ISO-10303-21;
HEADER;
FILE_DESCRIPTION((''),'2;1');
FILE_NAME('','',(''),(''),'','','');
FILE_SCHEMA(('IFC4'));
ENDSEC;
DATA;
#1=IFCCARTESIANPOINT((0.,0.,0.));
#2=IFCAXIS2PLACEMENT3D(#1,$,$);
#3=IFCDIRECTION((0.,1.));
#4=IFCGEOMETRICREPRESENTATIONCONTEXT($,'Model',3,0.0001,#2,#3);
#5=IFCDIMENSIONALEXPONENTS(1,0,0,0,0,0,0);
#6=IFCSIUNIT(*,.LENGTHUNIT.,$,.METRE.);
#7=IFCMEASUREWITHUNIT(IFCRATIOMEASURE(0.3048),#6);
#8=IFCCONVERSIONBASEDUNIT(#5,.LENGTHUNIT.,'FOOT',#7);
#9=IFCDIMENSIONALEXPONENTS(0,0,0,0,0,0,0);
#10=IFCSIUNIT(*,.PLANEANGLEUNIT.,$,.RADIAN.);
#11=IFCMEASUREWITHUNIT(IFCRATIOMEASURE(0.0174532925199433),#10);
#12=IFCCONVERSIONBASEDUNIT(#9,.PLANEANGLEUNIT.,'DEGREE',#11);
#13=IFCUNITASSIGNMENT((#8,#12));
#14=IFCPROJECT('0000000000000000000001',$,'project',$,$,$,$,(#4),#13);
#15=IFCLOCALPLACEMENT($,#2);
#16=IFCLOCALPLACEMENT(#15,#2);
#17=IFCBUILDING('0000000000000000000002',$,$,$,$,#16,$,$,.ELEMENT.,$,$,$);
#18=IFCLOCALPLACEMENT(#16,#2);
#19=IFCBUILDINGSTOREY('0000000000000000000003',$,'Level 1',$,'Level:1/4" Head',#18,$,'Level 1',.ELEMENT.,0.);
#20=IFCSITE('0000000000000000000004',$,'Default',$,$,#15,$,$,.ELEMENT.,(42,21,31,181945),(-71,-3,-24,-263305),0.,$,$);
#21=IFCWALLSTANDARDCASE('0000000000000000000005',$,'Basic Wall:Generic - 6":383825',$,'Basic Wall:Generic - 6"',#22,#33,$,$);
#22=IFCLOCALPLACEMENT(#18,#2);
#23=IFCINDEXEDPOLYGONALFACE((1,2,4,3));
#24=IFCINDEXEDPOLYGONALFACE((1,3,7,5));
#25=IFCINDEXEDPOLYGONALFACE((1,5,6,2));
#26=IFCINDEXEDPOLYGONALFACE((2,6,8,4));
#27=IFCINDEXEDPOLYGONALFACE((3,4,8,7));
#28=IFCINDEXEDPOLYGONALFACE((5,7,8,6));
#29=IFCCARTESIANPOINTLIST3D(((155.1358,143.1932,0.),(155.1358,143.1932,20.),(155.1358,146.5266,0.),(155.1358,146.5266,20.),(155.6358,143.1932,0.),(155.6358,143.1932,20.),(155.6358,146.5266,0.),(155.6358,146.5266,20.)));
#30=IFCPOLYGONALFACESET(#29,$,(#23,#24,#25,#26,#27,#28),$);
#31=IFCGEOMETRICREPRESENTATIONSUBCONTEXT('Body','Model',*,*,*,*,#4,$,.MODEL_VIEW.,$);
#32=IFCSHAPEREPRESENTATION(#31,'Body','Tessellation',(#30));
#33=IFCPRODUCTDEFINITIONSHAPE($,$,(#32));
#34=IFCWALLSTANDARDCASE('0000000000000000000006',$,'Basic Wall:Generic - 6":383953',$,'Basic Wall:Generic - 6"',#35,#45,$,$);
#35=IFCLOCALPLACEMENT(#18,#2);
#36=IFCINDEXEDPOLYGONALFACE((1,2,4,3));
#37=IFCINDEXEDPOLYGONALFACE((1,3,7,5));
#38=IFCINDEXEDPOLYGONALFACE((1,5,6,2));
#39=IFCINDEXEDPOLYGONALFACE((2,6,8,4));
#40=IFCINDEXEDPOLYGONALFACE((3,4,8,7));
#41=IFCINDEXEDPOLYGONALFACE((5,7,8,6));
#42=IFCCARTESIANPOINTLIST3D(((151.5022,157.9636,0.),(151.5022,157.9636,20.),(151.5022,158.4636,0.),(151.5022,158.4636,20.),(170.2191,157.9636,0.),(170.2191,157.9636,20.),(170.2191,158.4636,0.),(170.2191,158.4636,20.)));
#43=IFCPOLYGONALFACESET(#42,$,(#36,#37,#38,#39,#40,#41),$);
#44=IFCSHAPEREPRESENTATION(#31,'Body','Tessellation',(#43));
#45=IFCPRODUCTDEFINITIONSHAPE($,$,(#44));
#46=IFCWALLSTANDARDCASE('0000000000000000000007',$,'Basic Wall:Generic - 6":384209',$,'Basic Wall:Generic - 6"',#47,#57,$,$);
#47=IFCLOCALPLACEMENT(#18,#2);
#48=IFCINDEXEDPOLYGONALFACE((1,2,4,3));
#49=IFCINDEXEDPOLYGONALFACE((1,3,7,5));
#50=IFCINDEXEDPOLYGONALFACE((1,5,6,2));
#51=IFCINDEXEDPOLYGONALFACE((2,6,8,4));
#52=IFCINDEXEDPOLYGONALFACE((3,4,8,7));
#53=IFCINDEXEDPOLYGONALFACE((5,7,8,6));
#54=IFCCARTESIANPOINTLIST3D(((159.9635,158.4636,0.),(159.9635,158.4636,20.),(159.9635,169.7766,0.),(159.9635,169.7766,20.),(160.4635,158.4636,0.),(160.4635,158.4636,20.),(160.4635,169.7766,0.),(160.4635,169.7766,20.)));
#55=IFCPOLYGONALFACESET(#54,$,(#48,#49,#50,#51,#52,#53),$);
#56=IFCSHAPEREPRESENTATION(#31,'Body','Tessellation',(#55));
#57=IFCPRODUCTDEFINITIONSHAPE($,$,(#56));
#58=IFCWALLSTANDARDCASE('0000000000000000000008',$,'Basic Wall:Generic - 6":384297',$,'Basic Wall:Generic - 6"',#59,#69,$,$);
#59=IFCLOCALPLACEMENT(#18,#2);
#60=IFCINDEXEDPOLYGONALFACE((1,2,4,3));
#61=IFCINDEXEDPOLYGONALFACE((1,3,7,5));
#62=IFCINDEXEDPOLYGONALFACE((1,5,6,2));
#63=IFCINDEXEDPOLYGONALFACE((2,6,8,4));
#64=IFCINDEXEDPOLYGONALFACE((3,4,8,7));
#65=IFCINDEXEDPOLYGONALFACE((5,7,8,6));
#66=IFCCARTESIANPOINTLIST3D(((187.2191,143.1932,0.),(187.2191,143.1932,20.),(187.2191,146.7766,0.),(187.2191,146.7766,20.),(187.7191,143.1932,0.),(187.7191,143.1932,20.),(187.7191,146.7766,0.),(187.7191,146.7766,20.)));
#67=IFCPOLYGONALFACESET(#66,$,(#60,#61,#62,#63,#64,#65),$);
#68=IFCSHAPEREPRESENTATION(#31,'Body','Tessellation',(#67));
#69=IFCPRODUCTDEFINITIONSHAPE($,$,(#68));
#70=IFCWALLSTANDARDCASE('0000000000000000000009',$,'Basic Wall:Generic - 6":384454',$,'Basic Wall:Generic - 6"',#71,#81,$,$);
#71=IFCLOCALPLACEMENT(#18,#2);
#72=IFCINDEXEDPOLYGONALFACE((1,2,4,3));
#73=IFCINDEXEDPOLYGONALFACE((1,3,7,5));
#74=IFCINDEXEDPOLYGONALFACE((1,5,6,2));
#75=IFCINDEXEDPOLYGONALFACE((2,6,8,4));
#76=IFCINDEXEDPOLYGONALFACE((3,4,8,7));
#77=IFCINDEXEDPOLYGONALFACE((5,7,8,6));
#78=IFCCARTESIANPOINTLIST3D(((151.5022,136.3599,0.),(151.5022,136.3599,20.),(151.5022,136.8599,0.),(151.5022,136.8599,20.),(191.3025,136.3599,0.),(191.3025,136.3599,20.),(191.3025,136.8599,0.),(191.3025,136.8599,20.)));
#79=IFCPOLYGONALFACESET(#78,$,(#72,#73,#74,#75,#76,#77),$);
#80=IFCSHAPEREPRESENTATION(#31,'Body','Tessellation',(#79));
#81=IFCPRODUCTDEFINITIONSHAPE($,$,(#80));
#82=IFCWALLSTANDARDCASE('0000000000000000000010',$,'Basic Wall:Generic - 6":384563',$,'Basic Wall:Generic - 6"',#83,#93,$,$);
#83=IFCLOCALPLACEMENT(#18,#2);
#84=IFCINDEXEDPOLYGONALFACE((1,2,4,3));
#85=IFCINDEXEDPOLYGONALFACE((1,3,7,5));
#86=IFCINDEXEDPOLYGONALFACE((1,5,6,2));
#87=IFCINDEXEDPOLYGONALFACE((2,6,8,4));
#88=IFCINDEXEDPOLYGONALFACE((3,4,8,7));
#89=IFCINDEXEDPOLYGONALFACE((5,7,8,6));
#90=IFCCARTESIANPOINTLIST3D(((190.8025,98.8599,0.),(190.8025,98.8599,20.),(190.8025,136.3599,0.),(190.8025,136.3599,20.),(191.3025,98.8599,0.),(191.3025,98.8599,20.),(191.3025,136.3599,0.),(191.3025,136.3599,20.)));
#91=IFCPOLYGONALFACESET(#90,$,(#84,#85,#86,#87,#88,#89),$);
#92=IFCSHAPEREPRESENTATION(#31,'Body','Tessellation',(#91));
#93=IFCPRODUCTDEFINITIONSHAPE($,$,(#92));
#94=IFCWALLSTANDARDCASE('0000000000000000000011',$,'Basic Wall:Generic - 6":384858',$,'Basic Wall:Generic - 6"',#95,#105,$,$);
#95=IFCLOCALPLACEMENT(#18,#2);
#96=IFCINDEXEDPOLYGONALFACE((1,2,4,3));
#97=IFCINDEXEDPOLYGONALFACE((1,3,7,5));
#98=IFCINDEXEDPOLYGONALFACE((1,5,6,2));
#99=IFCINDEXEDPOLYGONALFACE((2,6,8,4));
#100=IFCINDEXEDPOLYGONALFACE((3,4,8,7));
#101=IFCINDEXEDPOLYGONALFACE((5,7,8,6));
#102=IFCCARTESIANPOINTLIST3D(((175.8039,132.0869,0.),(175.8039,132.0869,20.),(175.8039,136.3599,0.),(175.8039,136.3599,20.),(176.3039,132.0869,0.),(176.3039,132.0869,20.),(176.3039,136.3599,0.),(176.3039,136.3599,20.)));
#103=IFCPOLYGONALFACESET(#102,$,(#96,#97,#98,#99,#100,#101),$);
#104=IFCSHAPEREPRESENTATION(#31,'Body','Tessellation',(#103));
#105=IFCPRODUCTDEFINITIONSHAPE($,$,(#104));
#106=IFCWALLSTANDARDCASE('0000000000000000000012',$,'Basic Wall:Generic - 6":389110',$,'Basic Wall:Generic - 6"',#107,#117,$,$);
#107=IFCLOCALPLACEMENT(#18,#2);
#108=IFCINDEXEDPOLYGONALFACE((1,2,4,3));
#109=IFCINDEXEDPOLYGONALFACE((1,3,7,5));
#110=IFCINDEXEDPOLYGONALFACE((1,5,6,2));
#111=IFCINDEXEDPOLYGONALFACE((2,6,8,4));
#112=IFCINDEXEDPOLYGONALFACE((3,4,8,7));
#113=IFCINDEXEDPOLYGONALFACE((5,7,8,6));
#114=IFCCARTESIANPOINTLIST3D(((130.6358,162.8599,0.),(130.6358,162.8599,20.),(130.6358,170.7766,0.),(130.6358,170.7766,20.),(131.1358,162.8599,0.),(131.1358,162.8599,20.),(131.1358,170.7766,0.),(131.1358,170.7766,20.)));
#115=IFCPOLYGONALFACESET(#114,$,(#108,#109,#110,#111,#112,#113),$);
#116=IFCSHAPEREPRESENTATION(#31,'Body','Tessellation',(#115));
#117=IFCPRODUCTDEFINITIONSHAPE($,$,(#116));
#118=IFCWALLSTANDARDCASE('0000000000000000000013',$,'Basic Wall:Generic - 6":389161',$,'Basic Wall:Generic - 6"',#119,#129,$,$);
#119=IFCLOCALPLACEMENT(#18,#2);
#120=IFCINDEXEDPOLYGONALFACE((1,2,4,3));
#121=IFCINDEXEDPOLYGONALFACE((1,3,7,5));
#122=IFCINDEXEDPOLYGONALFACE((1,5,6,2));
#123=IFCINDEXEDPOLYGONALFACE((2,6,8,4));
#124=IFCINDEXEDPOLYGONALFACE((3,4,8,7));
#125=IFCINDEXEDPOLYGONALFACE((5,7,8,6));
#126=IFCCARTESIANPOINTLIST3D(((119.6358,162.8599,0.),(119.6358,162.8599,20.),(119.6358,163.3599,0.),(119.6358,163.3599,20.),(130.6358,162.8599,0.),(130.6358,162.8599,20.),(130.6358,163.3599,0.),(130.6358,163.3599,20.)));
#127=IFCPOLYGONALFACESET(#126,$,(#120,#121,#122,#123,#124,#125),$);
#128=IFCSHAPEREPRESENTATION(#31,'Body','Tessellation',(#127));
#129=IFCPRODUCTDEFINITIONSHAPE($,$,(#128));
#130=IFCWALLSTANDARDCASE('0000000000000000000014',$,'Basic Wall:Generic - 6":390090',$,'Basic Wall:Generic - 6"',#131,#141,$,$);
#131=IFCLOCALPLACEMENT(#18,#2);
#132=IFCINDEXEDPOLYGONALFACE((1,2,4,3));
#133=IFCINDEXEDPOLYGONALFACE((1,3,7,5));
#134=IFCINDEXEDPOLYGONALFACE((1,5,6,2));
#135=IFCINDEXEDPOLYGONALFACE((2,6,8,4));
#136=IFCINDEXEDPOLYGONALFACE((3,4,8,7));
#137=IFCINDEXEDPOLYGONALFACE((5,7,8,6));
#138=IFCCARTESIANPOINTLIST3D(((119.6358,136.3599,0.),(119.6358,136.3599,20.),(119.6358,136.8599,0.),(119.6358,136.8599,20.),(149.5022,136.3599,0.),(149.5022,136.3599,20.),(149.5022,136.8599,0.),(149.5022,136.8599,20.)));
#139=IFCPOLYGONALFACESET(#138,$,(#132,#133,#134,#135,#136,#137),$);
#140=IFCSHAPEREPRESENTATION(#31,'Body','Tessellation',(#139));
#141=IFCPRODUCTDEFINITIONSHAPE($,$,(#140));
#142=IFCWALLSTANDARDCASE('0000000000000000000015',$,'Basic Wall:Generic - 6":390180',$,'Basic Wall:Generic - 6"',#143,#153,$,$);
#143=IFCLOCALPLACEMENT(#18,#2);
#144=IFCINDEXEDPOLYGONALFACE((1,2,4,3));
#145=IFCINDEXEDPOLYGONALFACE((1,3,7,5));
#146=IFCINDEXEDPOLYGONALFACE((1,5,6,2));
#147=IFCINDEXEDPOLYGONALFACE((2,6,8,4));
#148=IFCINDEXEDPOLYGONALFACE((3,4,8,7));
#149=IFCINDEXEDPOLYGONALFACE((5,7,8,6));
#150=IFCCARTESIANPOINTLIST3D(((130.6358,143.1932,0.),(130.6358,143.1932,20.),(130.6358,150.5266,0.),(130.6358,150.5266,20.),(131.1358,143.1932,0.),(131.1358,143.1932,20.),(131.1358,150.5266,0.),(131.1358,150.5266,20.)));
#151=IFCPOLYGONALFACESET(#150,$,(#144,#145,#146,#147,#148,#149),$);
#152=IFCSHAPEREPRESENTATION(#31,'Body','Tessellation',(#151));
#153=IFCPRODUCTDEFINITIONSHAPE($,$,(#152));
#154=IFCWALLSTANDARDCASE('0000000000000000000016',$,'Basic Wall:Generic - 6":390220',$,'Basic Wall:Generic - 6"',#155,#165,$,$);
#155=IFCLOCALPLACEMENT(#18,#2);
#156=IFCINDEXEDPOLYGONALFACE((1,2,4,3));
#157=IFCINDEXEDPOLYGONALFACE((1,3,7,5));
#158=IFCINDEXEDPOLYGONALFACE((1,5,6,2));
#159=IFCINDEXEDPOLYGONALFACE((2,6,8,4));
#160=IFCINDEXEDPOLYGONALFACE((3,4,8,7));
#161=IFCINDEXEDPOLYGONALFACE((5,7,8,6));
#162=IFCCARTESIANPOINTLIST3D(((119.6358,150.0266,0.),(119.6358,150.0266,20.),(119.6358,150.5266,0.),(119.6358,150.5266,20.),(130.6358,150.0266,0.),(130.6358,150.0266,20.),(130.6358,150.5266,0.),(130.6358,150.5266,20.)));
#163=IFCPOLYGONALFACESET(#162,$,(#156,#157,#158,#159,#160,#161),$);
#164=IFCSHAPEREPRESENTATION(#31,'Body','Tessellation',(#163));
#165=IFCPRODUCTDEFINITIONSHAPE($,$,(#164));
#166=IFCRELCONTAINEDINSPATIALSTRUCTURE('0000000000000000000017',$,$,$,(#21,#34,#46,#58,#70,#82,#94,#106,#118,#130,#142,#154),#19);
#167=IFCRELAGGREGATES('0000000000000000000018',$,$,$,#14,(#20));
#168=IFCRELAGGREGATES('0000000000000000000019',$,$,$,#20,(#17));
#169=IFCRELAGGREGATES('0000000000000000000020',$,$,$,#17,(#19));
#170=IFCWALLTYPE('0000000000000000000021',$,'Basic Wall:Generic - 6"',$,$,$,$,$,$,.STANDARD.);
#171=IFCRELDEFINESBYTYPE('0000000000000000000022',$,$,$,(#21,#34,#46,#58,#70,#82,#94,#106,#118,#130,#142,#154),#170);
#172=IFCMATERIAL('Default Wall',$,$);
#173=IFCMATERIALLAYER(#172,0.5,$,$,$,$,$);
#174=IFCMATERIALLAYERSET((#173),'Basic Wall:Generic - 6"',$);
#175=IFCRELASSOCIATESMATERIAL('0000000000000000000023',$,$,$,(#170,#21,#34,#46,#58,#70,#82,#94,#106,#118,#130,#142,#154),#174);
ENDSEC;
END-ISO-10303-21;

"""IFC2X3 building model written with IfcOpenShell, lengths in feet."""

from ifc_helpers import new_model, entity, si_unit, converted_unit, direction, frame, frame_2d, origin, place, context, subcontext, project, spatial, rectangle, extrude, material, layer, layer_set, layer_usage, type_object, element, save


model = new_model("IFC2X3")

# Units and contexts
model_context = context("Model", 3, precision=0.0001, world=origin(), true_north=direction((0.0, 1.0)))
body_context = subcontext(model_context, "Body", "Model", "MODEL_VIEW")
ifc_project = project(units=[converted_unit("LENGTHUNIT", "FOOT", entity("IfcRatioMeasure", 0.3048), si_unit("LENGTHUNIT", "METRE"), dimensions=[1, 0, 0, 0, 0, 0, 0]), converted_unit("PLANEANGLEUNIT", "DEGREE", entity("IfcRatioMeasure", 0.0174532925199433), si_unit("PLANEANGLEUNIT", "RADIAN"), dimensions=[0, 0, 0, 0, 0, 0, 0])], contexts=[model_context])

# Site, building, storey
site_placement = place(None, origin())
site = spatial("IfcSite", under=ifc_project, at=site_placement, Name="Default", CompositionType="ELEMENT", RefLatitude=(42, 21, 31, 181945), RefLongitude=(-71, -3, -24, -263305), RefElevation=0.0)
building_placement = place(site_placement, origin())
building = spatial("IfcBuilding", under=site, at=building_placement, CompositionType="ELEMENT")
storey_placement = place(building_placement, origin())
storey = spatial("IfcBuildingStorey", under=building, at=storey_placement, Name="Level 1", ObjectType="Level:1/4\" Head", LongName="Level 1", CompositionType="ELEMENT", Elevation=0.0)

# Walls
ifc_material = material(Name="Default Wall")
ifc_layer_1 = layer(ifc_material, 0.5)
ifc_layer_set_1 = layer_set([ifc_layer_1], Name="Basic Wall:Generic - 6\"")
wall_type_1 = type_object("IfcWallType", Name="Basic Wall:Generic - 6\"", PredefinedType="STANDARD", material=ifc_layer_set_1)
ifc_layer_usage_1 = layer_usage(ifc_layer_set_1, "AXIS2", "NEGATIVE", 0.25)
wall_1_placement = place(storey_placement, frame((155.3858, 143.1932, 0.0), z_axis=(0.0, 0.0, 1.0), x_axis=(0.0, 1.0, 0.0)))
element("IfcWallStandardCase", 1, at=wall_1_placement, inside=storey, type_object=wall_type_1, material=ifc_layer_usage_1, Name="Basic Wall:Generic - 6\":383825", ObjectType="Basic Wall:Generic - 6\"", context=body_context, shape_type="SweptSolid", body=[
    extrude(rectangle(XDim=3.3333, YDim=0.5, at=frame_2d((1.6667, 0.0), x_axis=(-1.0, 0.0))), origin(), (0.0, 0.0, 1.0), 20.0),
])
ifc_layer_usage_2 = layer_usage(ifc_layer_set_1, "AXIS2", "NEGATIVE", 0.25)
wall_2_placement = place(storey_placement, frame((151.5022, 158.2136, 0.0)))
element("IfcWallStandardCase", 2, at=wall_2_placement, inside=storey, type_object=wall_type_1, material=ifc_layer_usage_2, Name="Basic Wall:Generic - 6\":383953", ObjectType="Basic Wall:Generic - 6\"", context=body_context, shape_type="SweptSolid", body=[
    extrude(rectangle(XDim=18.717, YDim=0.5, at=frame_2d((9.3585, 0.0), x_axis=(-1.0, 0.0))), origin(), (0.0, 0.0, 1.0), 20.0),
])
ifc_layer_usage_3 = layer_usage(ifc_layer_set_1, "AXIS2", "NEGATIVE", 0.25)
wall_3_placement = place(storey_placement, frame((160.2135, 169.7766, 0.0), z_axis=(0.0, 0.0, 1.0), x_axis=(0.0, -1.0, 0.0)))
element("IfcWallStandardCase", 3, at=wall_3_placement, inside=storey, type_object=wall_type_1, material=ifc_layer_usage_3, Name="Basic Wall:Generic - 6\":384209", ObjectType="Basic Wall:Generic - 6\"", context=body_context, shape_type="SweptSolid", body=[
    extrude(rectangle(XDim=11.313, YDim=0.5, at=frame_2d((5.6565, 0.0), x_axis=(-1.0, 0.0))), origin(), (0.0, 0.0, 1.0), 20.0),
])
ifc_layer_usage_4 = layer_usage(ifc_layer_set_1, "AXIS2", "NEGATIVE", 0.25)
wall_4_placement = place(storey_placement, frame((187.4691, 143.1932, 0.0), z_axis=(0.0, 0.0, 1.0), x_axis=(0.0, 1.0, 0.0)))
element("IfcWallStandardCase", 4, at=wall_4_placement, inside=storey, type_object=wall_type_1, material=ifc_layer_usage_4, Name="Basic Wall:Generic - 6\":384297", ObjectType="Basic Wall:Generic - 6\"", context=body_context, shape_type="SweptSolid", body=[
    extrude(rectangle(XDim=3.5833, YDim=0.5, at=frame_2d((1.7917, 0.0), x_axis=(-1.0, 0.0))), origin(), (0.0, 0.0, 1.0), 20.0),
])
ifc_layer_usage_5 = layer_usage(ifc_layer_set_1, "AXIS2", "NEGATIVE", 0.25)
wall_5_placement = place(storey_placement, frame((151.5022, 136.6099, 0.0)))
element("IfcWallStandardCase", 5, at=wall_5_placement, inside=storey, type_object=wall_type_1, material=ifc_layer_usage_5, Name="Basic Wall:Generic - 6\":384454", ObjectType="Basic Wall:Generic - 6\"", context=body_context, shape_type="SweptSolid", body=[
    extrude(rectangle(XDim=39.8003, YDim=0.5, at=frame_2d((19.9001, 0.0), x_axis=(-1.0, 0.0))), origin(), (0.0, 0.0, 1.0), 20.0),
])
ifc_layer_usage_6 = layer_usage(ifc_layer_set_1, "AXIS2", "NEGATIVE", 0.25)
wall_6_placement = place(storey_placement, frame((191.0525, 136.3599, 0.0), z_axis=(0.0, 0.0, 1.0), x_axis=(0.0, -1.0, 0.0)))
element("IfcWallStandardCase", 6, at=wall_6_placement, inside=storey, type_object=wall_type_1, material=ifc_layer_usage_6, Name="Basic Wall:Generic - 6\":384563", ObjectType="Basic Wall:Generic - 6\"", context=body_context, shape_type="SweptSolid", body=[
    extrude(rectangle(XDim=37.5, YDim=0.5, at=frame_2d((18.75, 0.0), x_axis=(-1.0, 0.0))), origin(), (0.0, 0.0, 1.0), 20.0),
])
ifc_layer_usage_7 = layer_usage(ifc_layer_set_1, "AXIS2", "NEGATIVE", 0.25)
wall_7_placement = place(storey_placement, frame((176.0539, 136.3599, 0.0), z_axis=(0.0, 0.0, 1.0), x_axis=(0.0, -1.0, 0.0)))
element("IfcWallStandardCase", 7, at=wall_7_placement, inside=storey, type_object=wall_type_1, material=ifc_layer_usage_7, Name="Basic Wall:Generic - 6\":384858", ObjectType="Basic Wall:Generic - 6\"", context=body_context, shape_type="SweptSolid", body=[
    extrude(rectangle(XDim=4.273, YDim=0.5, at=frame_2d((2.1365, 0.0), x_axis=(-1.0, 0.0))), origin(), (0.0, 0.0, 1.0), 20.0),
])
ifc_layer_usage_8 = layer_usage(ifc_layer_set_1, "AXIS2", "NEGATIVE", 0.25)
wall_8_placement = place(storey_placement, frame((130.8858, 170.7766, 0.0), z_axis=(0.0, 0.0, 1.0), x_axis=(0.0, -1.0, 0.0)))
element("IfcWallStandardCase", 8, at=wall_8_placement, inside=storey, type_object=wall_type_1, material=ifc_layer_usage_8, Name="Basic Wall:Generic - 6\":389110", ObjectType="Basic Wall:Generic - 6\"", context=body_context, shape_type="SweptSolid", body=[
    extrude(rectangle(XDim=7.9167, YDim=0.5, at=frame_2d((3.9583, 0.0), x_axis=(-1.0, 0.0))), origin(), (0.0, 0.0, 1.0), 20.0),
])
ifc_layer_usage_9 = layer_usage(ifc_layer_set_1, "AXIS2", "NEGATIVE", 0.25)
wall_9_placement = place(storey_placement, frame((130.6358, 163.1099, 0.0), z_axis=(0.0, 0.0, 1.0), x_axis=(-1.0, 0.0, 0.0)))
element("IfcWallStandardCase", 9, at=wall_9_placement, inside=storey, type_object=wall_type_1, material=ifc_layer_usage_9, Name="Basic Wall:Generic - 6\":389161", ObjectType="Basic Wall:Generic - 6\"", context=body_context, shape_type="SweptSolid", body=[
    extrude(rectangle(XDim=11.0, YDim=0.5, at=frame_2d((5.5, 0.0), x_axis=(-1.0, 0.0))), origin(), (0.0, 0.0, 1.0), 20.0),
])
ifc_layer_usage_10 = layer_usage(ifc_layer_set_1, "AXIS2", "NEGATIVE", 0.25)
wall_10_placement = place(storey_placement, frame((149.5022, 136.6099, 0.0), z_axis=(0.0, 0.0, 1.0), x_axis=(-1.0, 0.0, 0.0)))
element("IfcWallStandardCase", 10, at=wall_10_placement, inside=storey, type_object=wall_type_1, material=ifc_layer_usage_10, Name="Basic Wall:Generic - 6\":390090", ObjectType="Basic Wall:Generic - 6\"", context=body_context, shape_type="SweptSolid", body=[
    extrude(rectangle(XDim=29.8664, YDim=0.5, at=frame_2d((14.9332, 0.0), x_axis=(-1.0, 0.0))), origin(), (0.0, 0.0, 1.0), 20.0),
])
ifc_layer_usage_11 = layer_usage(ifc_layer_set_1, "AXIS2", "NEGATIVE", 0.25)
wall_11_placement = place(storey_placement, frame((130.8858, 143.1932, 0.0), z_axis=(0.0, 0.0, 1.0), x_axis=(0.0, 1.0, 0.0)))
element("IfcWallStandardCase", 11, at=wall_11_placement, inside=storey, type_object=wall_type_1, material=ifc_layer_usage_11, Name="Basic Wall:Generic - 6\":390180", ObjectType="Basic Wall:Generic - 6\"", context=body_context, shape_type="SweptSolid", body=[
    extrude(rectangle(XDim=7.3333, YDim=0.5, at=frame_2d((3.6667, 0.0), x_axis=(-1.0, 0.0))), origin(), (0.0, 0.0, 1.0), 20.0),
])
ifc_layer_usage_12 = layer_usage(ifc_layer_set_1, "AXIS2", "NEGATIVE", 0.25)
wall_12_placement = place(storey_placement, frame((130.6358, 150.2766, 0.0), z_axis=(0.0, 0.0, 1.0), x_axis=(-1.0, 0.0, 0.0)))
element("IfcWallStandardCase", 12, at=wall_12_placement, inside=storey, type_object=wall_type_1, material=ifc_layer_usage_12, Name="Basic Wall:Generic - 6\":390220", ObjectType="Basic Wall:Generic - 6\"", context=body_context, shape_type="SweptSolid", body=[
    extrude(rectangle(XDim=11.0, YDim=0.5, at=frame_2d((5.5, 0.0), x_axis=(-1.0, 0.0))), origin(), (0.0, 0.0, 1.0), 20.0),
])

save(model, "model.ifc")
